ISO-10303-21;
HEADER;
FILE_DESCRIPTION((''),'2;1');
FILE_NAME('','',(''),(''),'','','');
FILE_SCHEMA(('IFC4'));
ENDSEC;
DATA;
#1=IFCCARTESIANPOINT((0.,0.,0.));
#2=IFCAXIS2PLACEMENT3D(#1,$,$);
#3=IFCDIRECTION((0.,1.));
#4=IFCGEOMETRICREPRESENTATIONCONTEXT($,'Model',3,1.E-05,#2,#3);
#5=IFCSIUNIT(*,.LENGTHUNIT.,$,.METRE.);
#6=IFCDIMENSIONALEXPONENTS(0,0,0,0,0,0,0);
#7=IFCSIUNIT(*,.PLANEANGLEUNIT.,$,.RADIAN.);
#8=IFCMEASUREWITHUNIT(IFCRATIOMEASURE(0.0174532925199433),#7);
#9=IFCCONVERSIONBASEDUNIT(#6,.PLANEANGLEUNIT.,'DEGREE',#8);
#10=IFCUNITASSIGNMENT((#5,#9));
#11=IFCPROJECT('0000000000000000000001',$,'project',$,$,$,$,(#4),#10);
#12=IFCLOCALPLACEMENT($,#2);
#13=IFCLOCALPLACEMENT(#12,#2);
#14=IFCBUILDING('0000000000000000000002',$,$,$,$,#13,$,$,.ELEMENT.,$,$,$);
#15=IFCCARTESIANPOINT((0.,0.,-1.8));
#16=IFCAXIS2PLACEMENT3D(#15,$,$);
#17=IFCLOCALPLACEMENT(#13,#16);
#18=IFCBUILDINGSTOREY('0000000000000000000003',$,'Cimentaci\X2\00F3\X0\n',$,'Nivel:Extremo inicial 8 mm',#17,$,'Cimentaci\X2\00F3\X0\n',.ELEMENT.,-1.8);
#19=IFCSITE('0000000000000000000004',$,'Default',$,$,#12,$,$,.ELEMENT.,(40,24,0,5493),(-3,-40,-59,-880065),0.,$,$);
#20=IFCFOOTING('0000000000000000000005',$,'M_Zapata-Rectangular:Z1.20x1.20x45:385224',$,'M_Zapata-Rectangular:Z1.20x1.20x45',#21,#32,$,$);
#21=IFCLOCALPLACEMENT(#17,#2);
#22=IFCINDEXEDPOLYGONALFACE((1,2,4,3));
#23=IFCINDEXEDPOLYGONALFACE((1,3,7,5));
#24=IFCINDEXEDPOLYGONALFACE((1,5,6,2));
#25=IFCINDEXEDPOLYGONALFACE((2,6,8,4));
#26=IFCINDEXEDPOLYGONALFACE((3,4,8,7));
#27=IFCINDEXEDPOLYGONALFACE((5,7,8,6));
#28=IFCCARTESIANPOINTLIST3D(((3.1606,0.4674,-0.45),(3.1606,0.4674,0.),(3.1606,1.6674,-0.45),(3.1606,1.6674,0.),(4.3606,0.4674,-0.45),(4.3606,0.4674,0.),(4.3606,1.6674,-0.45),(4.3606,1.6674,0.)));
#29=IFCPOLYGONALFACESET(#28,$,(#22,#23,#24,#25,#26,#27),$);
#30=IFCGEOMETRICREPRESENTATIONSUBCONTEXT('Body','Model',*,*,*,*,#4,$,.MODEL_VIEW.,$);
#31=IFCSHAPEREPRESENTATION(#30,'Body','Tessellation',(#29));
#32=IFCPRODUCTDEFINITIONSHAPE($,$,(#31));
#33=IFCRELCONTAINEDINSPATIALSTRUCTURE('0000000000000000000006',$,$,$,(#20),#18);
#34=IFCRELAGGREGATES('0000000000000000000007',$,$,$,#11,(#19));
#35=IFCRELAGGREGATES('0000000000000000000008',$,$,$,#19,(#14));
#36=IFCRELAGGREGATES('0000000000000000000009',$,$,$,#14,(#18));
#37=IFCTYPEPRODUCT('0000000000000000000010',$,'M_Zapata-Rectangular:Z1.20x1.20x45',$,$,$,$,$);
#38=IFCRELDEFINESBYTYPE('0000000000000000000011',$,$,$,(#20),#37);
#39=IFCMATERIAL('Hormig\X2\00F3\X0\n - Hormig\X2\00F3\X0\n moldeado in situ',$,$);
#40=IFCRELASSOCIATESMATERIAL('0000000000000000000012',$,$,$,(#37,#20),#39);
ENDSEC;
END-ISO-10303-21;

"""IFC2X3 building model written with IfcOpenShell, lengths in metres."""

from ifc_helpers import new_model, entity, si_unit, converted_unit, direction, frame, origin, origin_2d_with_axis, place, context, subcontext, project, spatial, rectangle, extrude, source, transform, mapped, material, type_object, type_shapes, element, save


model = new_model("IFC2X3")

# Units and contexts
model_context = context("Model", 3, precision=1e-05, world=origin(), true_north=direction((0.0, 1.0)))
body_context = subcontext(model_context, "Body", "Model", "MODEL_VIEW")
ifc_project = project(units=[si_unit("LENGTHUNIT", "METRE"), converted_unit("PLANEANGLEUNIT", "DEGREE", entity("IfcRatioMeasure", 0.0174532925199433), si_unit("PLANEANGLEUNIT", "RADIAN"), dimensions=[0, 0, 0, 0, 0, 0, 0])], contexts=[model_context])

# Site, building, storey
site_placement = place(None, origin())
site = spatial("IfcSite", under=ifc_project, at=site_placement, Name="Default", CompositionType="ELEMENT", RefLatitude=(40, 24, 0, 5493), RefLongitude=(-3, -40, -59, -880065), RefElevation=0.0)
building_placement = place(site_placement, origin())
building = spatial("IfcBuilding", under=site, at=building_placement, CompositionType="ELEMENT")
storey_placement = place(building_placement, frame((0.0, 0.0, -1.8)))
storey = spatial("IfcBuildingStorey", under=building, at=storey_placement, Name="Cimentación", ObjectType="Nivel:Extremo inicial 8 mm", LongName="Cimentación", CompositionType="ELEMENT", Elevation=-1.8)

# Footing
ifc_material_1 = material(Name="Hormigón - Hormigón moldeado in situ")
type_product_1 = type_object("IfcTypeProduct", Name="M_Zapata-Rectangular:Z1.20x1.20x45", material=ifc_material_1)
shared_shape_1 = source(origin(), body_context, "Body", "SweptSolid", [
    extrude(rectangle(XDim=1.2, YDim=1.2, at=origin_2d_with_axis()), frame((0.0, 0.0, -0.45), z_axis=(0.0, 0.0, 1.0), x_axis=(-1.0, 0.0, 0.0)), (0.0, 0.0, 1.0), 0.45),
])
type_shapes(type_product_1, [shared_shape_1])
footing_1_placement = place(storey_placement, frame((3.7606, 1.0674, 0.0)))
element("IfcFooting", 1, at=footing_1_placement, inside=storey, type_object=type_product_1, material=ifc_material_1, Name="M_Zapata-Rectangular:Z1.20x1.20x45:385224", ObjectType="M_Zapata-Rectangular:Z1.20x1.20x45", context=body_context, shape_type="MappedRepresentation", body=[
    mapped(shared_shape_1, transform((0.0, 0.0, 0.0), scale=1.0)),
])

save(model, "model.ifc")
